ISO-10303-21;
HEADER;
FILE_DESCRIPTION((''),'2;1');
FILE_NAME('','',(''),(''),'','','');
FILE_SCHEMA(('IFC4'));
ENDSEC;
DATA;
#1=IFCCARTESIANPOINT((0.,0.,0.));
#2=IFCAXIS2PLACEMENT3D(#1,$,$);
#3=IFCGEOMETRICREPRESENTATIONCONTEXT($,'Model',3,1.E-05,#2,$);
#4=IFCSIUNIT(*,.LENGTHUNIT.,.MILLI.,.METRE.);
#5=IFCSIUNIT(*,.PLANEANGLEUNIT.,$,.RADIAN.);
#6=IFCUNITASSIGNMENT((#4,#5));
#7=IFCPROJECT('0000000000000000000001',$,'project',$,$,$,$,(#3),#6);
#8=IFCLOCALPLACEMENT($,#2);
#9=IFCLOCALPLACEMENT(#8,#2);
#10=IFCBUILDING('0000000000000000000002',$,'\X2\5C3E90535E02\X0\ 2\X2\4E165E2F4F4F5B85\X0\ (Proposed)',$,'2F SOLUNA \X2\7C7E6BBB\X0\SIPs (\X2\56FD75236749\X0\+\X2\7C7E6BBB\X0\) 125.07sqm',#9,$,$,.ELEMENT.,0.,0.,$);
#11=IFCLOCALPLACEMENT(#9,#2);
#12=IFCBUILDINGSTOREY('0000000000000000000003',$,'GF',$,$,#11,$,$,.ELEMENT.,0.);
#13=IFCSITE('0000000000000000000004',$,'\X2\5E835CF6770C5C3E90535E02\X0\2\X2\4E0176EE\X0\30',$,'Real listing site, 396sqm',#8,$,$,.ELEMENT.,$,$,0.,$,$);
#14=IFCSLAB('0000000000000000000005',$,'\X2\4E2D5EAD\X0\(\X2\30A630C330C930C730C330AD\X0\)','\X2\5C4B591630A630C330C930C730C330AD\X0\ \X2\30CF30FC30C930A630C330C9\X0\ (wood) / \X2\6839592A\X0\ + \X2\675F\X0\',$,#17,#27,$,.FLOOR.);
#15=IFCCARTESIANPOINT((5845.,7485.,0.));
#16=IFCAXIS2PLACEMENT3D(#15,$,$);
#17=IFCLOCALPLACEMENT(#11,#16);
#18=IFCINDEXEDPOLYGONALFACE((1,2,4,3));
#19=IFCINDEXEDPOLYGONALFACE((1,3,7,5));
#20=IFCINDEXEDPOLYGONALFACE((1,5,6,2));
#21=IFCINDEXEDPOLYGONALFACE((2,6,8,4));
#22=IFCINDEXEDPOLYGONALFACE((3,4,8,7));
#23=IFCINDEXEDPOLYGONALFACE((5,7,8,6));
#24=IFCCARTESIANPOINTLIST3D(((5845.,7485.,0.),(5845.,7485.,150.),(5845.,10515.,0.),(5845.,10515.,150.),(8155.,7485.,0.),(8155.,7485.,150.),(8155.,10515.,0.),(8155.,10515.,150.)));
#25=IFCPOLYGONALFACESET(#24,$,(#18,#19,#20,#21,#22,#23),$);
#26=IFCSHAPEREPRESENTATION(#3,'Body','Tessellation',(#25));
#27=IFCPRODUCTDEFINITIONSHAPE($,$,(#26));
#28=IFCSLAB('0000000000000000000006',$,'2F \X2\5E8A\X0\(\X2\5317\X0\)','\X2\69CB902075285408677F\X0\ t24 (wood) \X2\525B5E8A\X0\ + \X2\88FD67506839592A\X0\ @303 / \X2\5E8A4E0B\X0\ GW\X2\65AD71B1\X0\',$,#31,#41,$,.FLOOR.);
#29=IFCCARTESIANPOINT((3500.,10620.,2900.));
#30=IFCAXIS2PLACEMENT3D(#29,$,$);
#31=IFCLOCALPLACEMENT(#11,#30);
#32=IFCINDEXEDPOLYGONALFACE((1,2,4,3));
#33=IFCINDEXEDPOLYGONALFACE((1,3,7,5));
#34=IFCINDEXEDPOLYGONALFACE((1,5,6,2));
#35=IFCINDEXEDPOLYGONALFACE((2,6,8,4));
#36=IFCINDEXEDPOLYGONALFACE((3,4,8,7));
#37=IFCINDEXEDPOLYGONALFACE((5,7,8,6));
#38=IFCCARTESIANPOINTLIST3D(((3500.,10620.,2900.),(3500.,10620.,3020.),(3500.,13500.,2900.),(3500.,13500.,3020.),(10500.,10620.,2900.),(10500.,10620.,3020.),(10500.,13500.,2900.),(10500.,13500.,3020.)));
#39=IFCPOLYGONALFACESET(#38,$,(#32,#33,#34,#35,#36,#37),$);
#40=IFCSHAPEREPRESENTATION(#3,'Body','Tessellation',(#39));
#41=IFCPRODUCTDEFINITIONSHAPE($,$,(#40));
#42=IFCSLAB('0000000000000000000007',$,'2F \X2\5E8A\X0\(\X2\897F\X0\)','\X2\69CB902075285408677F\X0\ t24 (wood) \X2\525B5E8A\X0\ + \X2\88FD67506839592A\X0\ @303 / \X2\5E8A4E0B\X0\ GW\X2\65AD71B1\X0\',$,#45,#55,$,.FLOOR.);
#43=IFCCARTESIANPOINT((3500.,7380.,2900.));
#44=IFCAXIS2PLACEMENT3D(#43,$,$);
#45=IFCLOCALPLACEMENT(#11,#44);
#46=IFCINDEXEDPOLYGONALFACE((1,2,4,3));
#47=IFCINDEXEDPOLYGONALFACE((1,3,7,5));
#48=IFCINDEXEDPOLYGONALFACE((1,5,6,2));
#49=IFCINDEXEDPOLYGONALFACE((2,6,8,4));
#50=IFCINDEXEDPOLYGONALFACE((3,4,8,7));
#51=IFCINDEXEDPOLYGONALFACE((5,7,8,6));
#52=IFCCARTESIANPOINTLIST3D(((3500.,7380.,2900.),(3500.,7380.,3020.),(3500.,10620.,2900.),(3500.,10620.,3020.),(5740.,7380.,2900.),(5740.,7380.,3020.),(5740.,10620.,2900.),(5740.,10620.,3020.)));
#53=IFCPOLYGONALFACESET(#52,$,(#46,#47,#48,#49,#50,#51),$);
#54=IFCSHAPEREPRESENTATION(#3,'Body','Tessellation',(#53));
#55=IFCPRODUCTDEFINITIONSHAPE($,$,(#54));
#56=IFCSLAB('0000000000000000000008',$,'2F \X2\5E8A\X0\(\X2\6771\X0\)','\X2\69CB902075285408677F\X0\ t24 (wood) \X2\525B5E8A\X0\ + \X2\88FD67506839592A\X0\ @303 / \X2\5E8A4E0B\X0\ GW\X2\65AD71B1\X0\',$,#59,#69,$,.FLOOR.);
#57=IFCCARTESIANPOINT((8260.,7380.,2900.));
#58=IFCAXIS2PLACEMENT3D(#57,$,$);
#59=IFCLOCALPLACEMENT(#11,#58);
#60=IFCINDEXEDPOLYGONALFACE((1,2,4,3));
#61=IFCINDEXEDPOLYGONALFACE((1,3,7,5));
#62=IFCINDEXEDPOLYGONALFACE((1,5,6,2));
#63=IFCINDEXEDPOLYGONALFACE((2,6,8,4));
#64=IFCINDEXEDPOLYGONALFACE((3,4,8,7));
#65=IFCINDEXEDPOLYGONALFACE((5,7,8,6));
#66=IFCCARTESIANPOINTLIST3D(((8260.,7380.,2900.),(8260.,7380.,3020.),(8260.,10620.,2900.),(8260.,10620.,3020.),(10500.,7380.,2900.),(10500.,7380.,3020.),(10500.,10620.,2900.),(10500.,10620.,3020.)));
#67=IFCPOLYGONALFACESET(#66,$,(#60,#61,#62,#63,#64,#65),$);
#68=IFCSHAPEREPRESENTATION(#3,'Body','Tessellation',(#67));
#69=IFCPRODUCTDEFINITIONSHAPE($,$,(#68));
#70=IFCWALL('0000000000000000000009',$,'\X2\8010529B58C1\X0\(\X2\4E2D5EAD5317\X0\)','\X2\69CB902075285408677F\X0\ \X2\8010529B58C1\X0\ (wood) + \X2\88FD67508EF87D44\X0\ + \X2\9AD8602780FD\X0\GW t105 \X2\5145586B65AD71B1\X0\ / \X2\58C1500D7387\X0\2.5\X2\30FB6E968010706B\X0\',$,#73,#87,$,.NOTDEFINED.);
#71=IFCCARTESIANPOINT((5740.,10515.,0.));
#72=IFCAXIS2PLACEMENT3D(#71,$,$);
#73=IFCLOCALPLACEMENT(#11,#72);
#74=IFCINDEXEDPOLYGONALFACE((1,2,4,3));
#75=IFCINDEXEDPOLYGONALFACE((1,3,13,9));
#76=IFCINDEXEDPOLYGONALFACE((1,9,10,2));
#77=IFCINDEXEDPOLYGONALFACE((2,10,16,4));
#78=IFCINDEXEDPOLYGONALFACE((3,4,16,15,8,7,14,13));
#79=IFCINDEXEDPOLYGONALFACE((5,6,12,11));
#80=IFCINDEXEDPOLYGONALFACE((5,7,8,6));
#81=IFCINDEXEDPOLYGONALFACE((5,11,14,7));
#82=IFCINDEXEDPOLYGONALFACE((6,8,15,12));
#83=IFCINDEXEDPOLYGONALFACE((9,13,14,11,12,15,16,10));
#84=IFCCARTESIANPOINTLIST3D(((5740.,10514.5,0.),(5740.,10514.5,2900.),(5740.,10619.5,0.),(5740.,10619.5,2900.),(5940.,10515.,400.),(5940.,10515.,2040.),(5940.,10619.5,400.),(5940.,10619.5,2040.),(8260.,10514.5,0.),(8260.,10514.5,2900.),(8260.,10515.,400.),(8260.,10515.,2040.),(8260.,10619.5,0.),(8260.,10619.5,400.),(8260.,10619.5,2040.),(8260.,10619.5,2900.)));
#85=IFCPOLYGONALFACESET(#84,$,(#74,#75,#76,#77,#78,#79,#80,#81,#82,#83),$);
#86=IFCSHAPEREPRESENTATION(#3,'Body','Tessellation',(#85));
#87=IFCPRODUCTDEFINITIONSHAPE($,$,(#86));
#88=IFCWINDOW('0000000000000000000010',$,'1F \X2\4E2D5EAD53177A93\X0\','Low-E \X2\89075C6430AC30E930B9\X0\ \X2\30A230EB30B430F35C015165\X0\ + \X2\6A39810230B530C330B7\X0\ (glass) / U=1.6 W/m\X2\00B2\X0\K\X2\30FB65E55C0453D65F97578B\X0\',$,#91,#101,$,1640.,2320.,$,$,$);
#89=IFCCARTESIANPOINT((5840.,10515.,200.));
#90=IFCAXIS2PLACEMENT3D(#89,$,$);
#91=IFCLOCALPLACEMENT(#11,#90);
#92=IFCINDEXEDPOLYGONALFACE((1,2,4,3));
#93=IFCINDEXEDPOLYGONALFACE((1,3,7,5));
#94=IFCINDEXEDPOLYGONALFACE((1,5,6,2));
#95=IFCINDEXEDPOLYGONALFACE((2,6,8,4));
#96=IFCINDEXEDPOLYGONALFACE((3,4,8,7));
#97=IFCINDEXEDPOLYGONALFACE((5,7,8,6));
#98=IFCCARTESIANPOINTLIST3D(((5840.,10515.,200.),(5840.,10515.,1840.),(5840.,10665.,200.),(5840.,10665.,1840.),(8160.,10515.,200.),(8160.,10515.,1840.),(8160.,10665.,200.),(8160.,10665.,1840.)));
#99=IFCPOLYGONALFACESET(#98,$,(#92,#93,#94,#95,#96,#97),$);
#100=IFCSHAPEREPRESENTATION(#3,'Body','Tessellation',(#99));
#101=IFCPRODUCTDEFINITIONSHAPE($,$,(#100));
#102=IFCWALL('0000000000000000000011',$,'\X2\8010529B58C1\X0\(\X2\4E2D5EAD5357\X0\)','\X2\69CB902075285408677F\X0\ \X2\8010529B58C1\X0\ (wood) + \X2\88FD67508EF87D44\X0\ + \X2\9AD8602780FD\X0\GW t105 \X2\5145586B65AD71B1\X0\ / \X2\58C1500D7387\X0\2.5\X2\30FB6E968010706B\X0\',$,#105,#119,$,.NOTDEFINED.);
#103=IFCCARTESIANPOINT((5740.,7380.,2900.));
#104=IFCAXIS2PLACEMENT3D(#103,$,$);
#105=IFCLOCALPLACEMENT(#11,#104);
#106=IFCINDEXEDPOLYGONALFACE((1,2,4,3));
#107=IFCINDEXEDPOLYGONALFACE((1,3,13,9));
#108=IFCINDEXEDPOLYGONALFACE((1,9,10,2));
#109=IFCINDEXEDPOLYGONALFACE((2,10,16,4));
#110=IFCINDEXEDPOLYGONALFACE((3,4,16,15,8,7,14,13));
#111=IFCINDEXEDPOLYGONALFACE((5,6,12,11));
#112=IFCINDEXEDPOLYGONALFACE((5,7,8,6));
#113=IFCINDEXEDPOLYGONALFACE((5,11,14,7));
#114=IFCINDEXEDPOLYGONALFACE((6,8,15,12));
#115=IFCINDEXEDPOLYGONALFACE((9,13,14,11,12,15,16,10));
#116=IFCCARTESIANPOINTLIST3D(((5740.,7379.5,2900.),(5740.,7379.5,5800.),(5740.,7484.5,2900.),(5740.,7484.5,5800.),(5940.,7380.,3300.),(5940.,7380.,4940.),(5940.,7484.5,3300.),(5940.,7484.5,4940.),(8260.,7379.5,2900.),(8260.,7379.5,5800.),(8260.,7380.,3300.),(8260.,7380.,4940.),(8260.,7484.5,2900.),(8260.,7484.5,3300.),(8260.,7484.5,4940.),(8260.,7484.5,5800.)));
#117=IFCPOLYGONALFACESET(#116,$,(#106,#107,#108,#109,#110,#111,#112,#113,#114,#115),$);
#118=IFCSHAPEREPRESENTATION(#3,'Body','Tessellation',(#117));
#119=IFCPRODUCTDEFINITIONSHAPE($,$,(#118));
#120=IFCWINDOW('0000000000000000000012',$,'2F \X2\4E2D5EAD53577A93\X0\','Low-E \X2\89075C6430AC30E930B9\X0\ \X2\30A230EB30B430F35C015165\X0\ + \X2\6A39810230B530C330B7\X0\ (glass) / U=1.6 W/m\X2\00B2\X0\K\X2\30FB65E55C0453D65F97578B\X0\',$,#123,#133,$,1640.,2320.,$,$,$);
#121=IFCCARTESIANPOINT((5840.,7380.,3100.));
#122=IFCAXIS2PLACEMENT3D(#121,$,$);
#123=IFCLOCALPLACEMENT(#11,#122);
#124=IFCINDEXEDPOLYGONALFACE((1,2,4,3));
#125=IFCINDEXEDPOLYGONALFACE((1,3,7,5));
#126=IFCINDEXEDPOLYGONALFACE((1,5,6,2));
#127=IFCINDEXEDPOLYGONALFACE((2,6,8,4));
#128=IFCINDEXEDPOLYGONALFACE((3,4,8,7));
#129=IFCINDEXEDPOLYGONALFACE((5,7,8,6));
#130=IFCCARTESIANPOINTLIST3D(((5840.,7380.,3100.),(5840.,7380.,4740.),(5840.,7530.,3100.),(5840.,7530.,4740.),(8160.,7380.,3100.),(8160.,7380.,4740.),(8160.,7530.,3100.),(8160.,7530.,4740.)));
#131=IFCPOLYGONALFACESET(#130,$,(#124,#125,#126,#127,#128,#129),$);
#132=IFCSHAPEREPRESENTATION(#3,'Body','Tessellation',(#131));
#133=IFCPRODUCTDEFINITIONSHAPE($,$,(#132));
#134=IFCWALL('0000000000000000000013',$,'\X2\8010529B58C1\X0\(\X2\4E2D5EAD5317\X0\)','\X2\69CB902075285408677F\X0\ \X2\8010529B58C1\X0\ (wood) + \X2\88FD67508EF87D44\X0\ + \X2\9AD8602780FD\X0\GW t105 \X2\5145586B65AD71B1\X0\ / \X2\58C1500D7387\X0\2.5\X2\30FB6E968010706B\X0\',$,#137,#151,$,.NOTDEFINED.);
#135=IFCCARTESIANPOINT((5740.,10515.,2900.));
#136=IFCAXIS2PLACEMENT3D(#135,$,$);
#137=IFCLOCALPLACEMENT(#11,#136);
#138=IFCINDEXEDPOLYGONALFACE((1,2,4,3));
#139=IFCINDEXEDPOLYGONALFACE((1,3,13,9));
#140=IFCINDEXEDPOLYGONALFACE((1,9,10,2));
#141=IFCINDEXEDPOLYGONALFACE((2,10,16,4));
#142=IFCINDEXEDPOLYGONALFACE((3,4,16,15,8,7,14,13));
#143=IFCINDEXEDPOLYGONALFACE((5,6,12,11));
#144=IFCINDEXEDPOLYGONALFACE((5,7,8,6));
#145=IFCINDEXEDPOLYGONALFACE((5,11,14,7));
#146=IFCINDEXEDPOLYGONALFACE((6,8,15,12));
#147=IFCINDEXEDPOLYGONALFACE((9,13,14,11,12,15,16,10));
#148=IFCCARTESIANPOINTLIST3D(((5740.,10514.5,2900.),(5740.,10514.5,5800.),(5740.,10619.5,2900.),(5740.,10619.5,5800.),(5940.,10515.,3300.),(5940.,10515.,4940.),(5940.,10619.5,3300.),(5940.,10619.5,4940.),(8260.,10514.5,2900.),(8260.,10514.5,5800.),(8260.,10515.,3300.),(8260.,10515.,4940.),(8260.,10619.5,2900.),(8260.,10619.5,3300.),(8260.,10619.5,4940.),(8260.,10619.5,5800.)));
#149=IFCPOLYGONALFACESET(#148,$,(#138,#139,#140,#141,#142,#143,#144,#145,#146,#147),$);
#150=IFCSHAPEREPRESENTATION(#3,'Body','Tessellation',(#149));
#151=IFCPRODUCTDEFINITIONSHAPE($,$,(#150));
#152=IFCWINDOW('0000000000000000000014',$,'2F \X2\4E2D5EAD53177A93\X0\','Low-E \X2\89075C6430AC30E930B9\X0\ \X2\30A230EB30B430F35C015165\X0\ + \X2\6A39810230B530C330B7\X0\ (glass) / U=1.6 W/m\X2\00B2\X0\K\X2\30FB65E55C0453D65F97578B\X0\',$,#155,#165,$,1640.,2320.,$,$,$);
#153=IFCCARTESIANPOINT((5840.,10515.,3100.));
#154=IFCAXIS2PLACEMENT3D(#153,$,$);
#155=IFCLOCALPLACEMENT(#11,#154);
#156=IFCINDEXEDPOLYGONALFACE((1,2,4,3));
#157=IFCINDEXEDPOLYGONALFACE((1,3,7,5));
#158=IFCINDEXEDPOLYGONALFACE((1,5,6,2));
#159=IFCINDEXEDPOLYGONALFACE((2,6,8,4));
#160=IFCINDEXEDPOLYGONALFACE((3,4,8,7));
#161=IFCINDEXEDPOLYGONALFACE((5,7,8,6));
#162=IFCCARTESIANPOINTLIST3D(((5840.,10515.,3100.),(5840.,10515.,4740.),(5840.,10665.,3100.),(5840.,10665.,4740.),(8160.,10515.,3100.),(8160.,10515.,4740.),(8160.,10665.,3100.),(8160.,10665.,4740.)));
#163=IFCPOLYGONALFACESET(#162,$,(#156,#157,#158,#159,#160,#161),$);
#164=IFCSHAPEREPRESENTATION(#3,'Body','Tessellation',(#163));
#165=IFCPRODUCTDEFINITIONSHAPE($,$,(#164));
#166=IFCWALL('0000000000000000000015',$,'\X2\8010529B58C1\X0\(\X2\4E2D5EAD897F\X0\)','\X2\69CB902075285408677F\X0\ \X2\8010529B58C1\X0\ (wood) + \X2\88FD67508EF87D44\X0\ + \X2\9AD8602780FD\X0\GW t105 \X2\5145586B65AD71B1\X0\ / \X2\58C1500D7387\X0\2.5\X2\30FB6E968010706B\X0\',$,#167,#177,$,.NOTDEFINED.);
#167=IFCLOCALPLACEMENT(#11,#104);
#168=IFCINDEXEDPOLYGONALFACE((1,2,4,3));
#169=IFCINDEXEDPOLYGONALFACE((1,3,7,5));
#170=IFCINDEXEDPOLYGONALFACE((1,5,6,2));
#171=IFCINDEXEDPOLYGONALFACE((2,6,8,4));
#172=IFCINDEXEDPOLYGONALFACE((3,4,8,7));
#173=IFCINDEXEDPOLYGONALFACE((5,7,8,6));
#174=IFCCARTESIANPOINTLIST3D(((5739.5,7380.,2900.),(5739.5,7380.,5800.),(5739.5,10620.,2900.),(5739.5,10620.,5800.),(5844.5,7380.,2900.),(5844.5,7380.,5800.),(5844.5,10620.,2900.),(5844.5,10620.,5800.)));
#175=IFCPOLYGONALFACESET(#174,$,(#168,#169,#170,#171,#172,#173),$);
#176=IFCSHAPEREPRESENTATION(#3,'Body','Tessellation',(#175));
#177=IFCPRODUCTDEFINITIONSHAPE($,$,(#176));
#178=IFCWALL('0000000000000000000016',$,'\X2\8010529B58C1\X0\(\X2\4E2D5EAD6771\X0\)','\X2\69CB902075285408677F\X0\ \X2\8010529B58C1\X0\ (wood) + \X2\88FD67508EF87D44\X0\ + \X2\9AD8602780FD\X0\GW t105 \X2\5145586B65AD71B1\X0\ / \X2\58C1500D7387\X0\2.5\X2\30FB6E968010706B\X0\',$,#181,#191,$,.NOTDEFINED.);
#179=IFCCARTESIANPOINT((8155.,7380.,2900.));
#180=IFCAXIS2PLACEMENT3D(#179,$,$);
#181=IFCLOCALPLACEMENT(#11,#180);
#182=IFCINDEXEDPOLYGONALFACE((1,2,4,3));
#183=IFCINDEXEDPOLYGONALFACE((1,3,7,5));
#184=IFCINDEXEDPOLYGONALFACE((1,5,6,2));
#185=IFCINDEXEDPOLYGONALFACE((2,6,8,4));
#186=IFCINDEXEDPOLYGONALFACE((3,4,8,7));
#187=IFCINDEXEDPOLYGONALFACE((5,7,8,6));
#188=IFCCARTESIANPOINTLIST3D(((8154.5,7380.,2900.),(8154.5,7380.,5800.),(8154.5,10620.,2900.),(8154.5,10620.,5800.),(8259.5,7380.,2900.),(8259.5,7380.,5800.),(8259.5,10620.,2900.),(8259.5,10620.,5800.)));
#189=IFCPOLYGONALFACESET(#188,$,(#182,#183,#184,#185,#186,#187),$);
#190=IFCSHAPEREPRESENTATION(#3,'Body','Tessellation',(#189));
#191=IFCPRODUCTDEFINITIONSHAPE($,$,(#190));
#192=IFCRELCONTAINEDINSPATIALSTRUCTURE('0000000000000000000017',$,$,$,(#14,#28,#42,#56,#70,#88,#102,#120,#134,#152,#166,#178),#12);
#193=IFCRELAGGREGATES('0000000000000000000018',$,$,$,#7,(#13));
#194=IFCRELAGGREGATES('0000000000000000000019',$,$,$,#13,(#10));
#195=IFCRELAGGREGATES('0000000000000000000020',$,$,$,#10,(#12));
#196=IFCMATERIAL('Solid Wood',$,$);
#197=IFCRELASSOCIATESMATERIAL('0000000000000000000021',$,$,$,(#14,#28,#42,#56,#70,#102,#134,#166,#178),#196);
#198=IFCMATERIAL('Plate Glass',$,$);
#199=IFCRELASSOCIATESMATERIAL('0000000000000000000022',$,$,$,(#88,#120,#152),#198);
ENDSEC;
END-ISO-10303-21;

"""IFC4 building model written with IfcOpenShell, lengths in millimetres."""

from ifc_helpers import new_model, si_unit, frame, frame_2d, origin, place, context, project, spatial, rectangle, extrude, material, element, fill, save


model = new_model("IFC4")

# Units and contexts
model_context = context("Model", 3, precision=1e-05, world=origin())
ifc_project = project(units=[si_unit("LENGTHUNIT", "METRE", prefix="MILLI"), si_unit("PLANEANGLEUNIT", "RADIAN")], contexts=[model_context])

# Site, building, storey
site_placement = place(None, origin())
site = spatial("IfcSite", under=ifc_project, at=site_placement, Name="広島県尾道市2丁目30", ObjectType="Real listing site, 396sqm", CompositionType="ELEMENT", RefElevation=0.0)
building_placement = place(site_placement, origin())
building = spatial("IfcBuilding", under=site, at=building_placement, Name="尾道市 2世帯住宅 (Proposed)", ObjectType="2F SOLUNA 籾殻SIPs (国産杉+籾殻) 125.07sqm", CompositionType="ELEMENT", ElevationOfRefHeight=0.0, ElevationOfTerrain=0.0)
storey_placement = place(building_placement, origin())
storey = spatial("IfcBuildingStorey", under=building, at=storey_placement, Name="GF", CompositionType="ELEMENT", Elevation=0.0)

# Slabs
ifc_material_1 = material(Name="Solid Wood")
slab_1_placement = place(storey_placement, frame((5845.0, 7485.0, 0.0)))
element("IfcSlab", 1, at=slab_1_placement, inside=storey, material=ifc_material_1, Name="中庭(ウッドデッキ)", Description="屋外ウッドデッキ ハードウッド (wood) / 根太 + 束", PredefinedType="FLOOR", context=model_context, shape_type="SweptSolid", body=[
    extrude(rectangle(XDim=2310.0, YDim=3030.0, at=frame_2d((1155.0, 1515.0))), frame((5845.0, 7485.0, 0.0)), (0.0, 0.0, 1.0), 150.0),
])
slab_2_placement = place(storey_placement, frame((3500.0, 10620.0, 2900.0)))
element("IfcSlab", 2, at=slab_2_placement, inside=storey, material=ifc_material_1, Name="2F 床(北)", Description="構造用合板 t24 (wood) 剛床 + 製材根太 @303 / 床下 GW断熱", PredefinedType="FLOOR", context=model_context, shape_type="SweptSolid", body=[
    extrude(rectangle(XDim=7000.0, YDim=2880.0, at=frame_2d((3500.0, 1440.0))), frame((3500.0, 10620.0, 2900.0)), (0.0, 0.0, 1.0), 120.0),
])
slab_3_placement = place(storey_placement, frame((3500.0, 7380.0, 2900.0)))
element("IfcSlab", 3, at=slab_3_placement, inside=storey, material=ifc_material_1, Name="2F 床(西)", Description="構造用合板 t24 (wood) 剛床 + 製材根太 @303 / 床下 GW断熱", PredefinedType="FLOOR", context=model_context, shape_type="SweptSolid", body=[
    extrude(rectangle(XDim=2240.0, YDim=3240.0, at=frame_2d((1120.0, 1620.0))), frame((3500.0, 7380.0, 2900.0)), (0.0, 0.0, 1.0), 120.0),
])
slab_4_placement = place(storey_placement, frame((8260.0, 7380.0, 2900.0)))
element("IfcSlab", 4, at=slab_4_placement, inside=storey, material=ifc_material_1, Name="2F 床(東)", Description="構造用合板 t24 (wood) 剛床 + 製材根太 @303 / 床下 GW断熱", PredefinedType="FLOOR", context=model_context, shape_type="SweptSolid", body=[
    extrude(rectangle(XDim=2240.0, YDim=3240.0, at=frame_2d((1120.0, 1620.0))), frame((8260.0, 7380.0, 2900.0)), (0.0, 0.0, 1.0), 120.0),
])

# Wall, opening, window
wall_1_placement = place(storey_placement, frame((5740.0, 10515.0, 0.0)))
wall_1 = element("IfcWall", 5, at=wall_1_placement, inside=storey, material=ifc_material_1, Name="耐力壁(中庭北)", Description="構造用合板 耐力壁 (wood) + 製材軸組 + 高性能GW t105 充填断熱 / 壁倍率2.5・準耐火", PredefinedType="NOTDEFINED", context=model_context, shape_type="SweptSolid", body=[
    extrude(rectangle(XDim=2520.0, YDim=105.0, at=frame_2d((1260.0, 52.0))), frame((5740.0, 10515.0, 0.0)), (0.0, 0.0, 1.0), 2900.0),
])
opening_1_placement = place(storey_placement, frame((5840.0, 10515.0, 200.0)))
opening_1 = element("IfcOpeningElement", 6, at=opening_1_placement, cuts=wall_1, PredefinedType="NOTDEFINED", context=model_context, shape_type="SweptSolid", body=[
    extrude(rectangle(XDim=2320.0, YDim=150.0, at=frame_2d((1160.0, 75.0))), frame((5840.0, 10515.0, 200.0)), (0.0, 0.0, 1.0), 1640.0),
])
ifc_material_2 = material(Name="Plate Glass")
window_1_placement = place(storey_placement, frame((5840.0, 10515.0, 200.0)))
window_1 = element("IfcWindow", 7, at=window_1_placement, inside=storey, material=ifc_material_2, Name="1F 中庭北窓", Description="Low-E 複層ガラス アルゴン封入 + 樹脂サッシ (glass) / U=1.6 W/m²K・日射取得型", OverallHeight=1640.0, OverallWidth=2320.0, context=model_context, shape_type="SweptSolid", body=[
    extrude(rectangle(XDim=2320.0, YDim=150.0, at=frame_2d((1160.0, 75.0))), frame((5840.0, 10515.0, 200.0)), (0.0, 0.0, 1.0), 1640.0),
])
fill(opening_1, window_1)

# Walls, openings, windows
wall_2_placement = place(storey_placement, frame((5740.0, 7380.0, 2900.0)))
wall_2 = element("IfcWall", 8, at=wall_2_placement, inside=storey, material=ifc_material_1, Name="耐力壁(中庭南)", Description="構造用合板 耐力壁 (wood) + 製材軸組 + 高性能GW t105 充填断熱 / 壁倍率2.5・準耐火", PredefinedType="NOTDEFINED", context=model_context, shape_type="SweptSolid", body=[
    extrude(rectangle(XDim=2520.0, YDim=105.0, at=frame_2d((1260.0, 52.0))), frame((5740.0, 7380.0, 2900.0)), (0.0, 0.0, 1.0), 2900.0),
])
opening_2_placement = place(storey_placement, frame((5840.0, 7380.0, 3100.0)))
opening_2 = element("IfcOpeningElement", 9, at=opening_2_placement, cuts=wall_2, PredefinedType="NOTDEFINED", context=model_context, shape_type="SweptSolid", body=[
    extrude(rectangle(XDim=2320.0, YDim=150.0, at=frame_2d((1160.0, 75.0))), frame((5840.0, 7380.0, 3100.0)), (0.0, 0.0, 1.0), 1640.0),
])
window_2_placement = place(storey_placement, frame((5840.0, 7380.0, 3100.0)))
window_2 = element("IfcWindow", 10, at=window_2_placement, inside=storey, material=ifc_material_2, Name="2F 中庭南窓", Description="Low-E 複層ガラス アルゴン封入 + 樹脂サッシ (glass) / U=1.6 W/m²K・日射取得型", OverallHeight=1640.0, OverallWidth=2320.0, context=model_context, shape_type="SweptSolid", body=[
    extrude(rectangle(XDim=2320.0, YDim=150.0, at=frame_2d((1160.0, 75.0))), frame((5840.0, 7380.0, 3100.0)), (0.0, 0.0, 1.0), 1640.0),
])
fill(opening_2, window_2)
wall_3_placement = place(storey_placement, frame((5740.0, 10515.0, 2900.0)))
wall_3 = element("IfcWall", 11, at=wall_3_placement, inside=storey, material=ifc_material_1, Name="耐力壁(中庭北)", Description="構造用合板 耐力壁 (wood) + 製材軸組 + 高性能GW t105 充填断熱 / 壁倍率2.5・準耐火", PredefinedType="NOTDEFINED", context=model_context, shape_type="SweptSolid", body=[
    extrude(rectangle(XDim=2520.0, YDim=105.0, at=frame_2d((1260.0, 52.0))), frame((5740.0, 10515.0, 2900.0)), (0.0, 0.0, 1.0), 2900.0),
])
opening_3_placement = place(storey_placement, frame((5840.0, 10515.0, 3100.0)))
opening_3 = element("IfcOpeningElement", 12, at=opening_3_placement, cuts=wall_3, PredefinedType="NOTDEFINED", context=model_context, shape_type="SweptSolid", body=[
    extrude(rectangle(XDim=2320.0, YDim=150.0, at=frame_2d((1160.0, 75.0))), frame((5840.0, 10515.0, 3100.0)), (0.0, 0.0, 1.0), 1640.0),
])
window_3_placement = place(storey_placement, frame((5840.0, 10515.0, 3100.0)))
window_3 = element("IfcWindow", 13, at=window_3_placement, inside=storey, material=ifc_material_2, Name="2F 中庭北窓", Description="Low-E 複層ガラス アルゴン封入 + 樹脂サッシ (glass) / U=1.6 W/m²K・日射取得型", OverallHeight=1640.0, OverallWidth=2320.0, context=model_context, shape_type="SweptSolid", body=[
    extrude(rectangle(XDim=2320.0, YDim=150.0, at=frame_2d((1160.0, 75.0))), frame((5840.0, 10515.0, 3100.0)), (0.0, 0.0, 1.0), 1640.0),
])
fill(opening_3, window_3)

# Walls
wall_4_placement = place(storey_placement, frame((5740.0, 7380.0, 2900.0)))
element("IfcWall", 14, at=wall_4_placement, inside=storey, material=ifc_material_1, Name="耐力壁(中庭西)", Description="構造用合板 耐力壁 (wood) + 製材軸組 + 高性能GW t105 充填断熱 / 壁倍率2.5・準耐火", PredefinedType="NOTDEFINED", context=model_context, shape_type="SweptSolid", body=[
    extrude(rectangle(XDim=105.0, YDim=3240.0, at=frame_2d((52.0, 1620.0))), frame((5740.0, 7380.0, 2900.0)), (0.0, 0.0, 1.0), 2900.0),
])
wall_5_placement = place(storey_placement, frame((8155.0, 7380.0, 2900.0)))
element("IfcWall", 15, at=wall_5_placement, inside=storey, material=ifc_material_1, Name="耐力壁(中庭東)", Description="構造用合板 耐力壁 (wood) + 製材軸組 + 高性能GW t105 充填断熱 / 壁倍率2.5・準耐火", PredefinedType="NOTDEFINED", context=model_context, shape_type="SweptSolid", body=[
    extrude(rectangle(XDim=105.0, YDim=3240.0, at=frame_2d((52.0, 1620.0))), frame((8155.0, 7380.0, 2900.0)), (0.0, 0.0, 1.0), 2900.0),
])

save(model, "model.ifc")
